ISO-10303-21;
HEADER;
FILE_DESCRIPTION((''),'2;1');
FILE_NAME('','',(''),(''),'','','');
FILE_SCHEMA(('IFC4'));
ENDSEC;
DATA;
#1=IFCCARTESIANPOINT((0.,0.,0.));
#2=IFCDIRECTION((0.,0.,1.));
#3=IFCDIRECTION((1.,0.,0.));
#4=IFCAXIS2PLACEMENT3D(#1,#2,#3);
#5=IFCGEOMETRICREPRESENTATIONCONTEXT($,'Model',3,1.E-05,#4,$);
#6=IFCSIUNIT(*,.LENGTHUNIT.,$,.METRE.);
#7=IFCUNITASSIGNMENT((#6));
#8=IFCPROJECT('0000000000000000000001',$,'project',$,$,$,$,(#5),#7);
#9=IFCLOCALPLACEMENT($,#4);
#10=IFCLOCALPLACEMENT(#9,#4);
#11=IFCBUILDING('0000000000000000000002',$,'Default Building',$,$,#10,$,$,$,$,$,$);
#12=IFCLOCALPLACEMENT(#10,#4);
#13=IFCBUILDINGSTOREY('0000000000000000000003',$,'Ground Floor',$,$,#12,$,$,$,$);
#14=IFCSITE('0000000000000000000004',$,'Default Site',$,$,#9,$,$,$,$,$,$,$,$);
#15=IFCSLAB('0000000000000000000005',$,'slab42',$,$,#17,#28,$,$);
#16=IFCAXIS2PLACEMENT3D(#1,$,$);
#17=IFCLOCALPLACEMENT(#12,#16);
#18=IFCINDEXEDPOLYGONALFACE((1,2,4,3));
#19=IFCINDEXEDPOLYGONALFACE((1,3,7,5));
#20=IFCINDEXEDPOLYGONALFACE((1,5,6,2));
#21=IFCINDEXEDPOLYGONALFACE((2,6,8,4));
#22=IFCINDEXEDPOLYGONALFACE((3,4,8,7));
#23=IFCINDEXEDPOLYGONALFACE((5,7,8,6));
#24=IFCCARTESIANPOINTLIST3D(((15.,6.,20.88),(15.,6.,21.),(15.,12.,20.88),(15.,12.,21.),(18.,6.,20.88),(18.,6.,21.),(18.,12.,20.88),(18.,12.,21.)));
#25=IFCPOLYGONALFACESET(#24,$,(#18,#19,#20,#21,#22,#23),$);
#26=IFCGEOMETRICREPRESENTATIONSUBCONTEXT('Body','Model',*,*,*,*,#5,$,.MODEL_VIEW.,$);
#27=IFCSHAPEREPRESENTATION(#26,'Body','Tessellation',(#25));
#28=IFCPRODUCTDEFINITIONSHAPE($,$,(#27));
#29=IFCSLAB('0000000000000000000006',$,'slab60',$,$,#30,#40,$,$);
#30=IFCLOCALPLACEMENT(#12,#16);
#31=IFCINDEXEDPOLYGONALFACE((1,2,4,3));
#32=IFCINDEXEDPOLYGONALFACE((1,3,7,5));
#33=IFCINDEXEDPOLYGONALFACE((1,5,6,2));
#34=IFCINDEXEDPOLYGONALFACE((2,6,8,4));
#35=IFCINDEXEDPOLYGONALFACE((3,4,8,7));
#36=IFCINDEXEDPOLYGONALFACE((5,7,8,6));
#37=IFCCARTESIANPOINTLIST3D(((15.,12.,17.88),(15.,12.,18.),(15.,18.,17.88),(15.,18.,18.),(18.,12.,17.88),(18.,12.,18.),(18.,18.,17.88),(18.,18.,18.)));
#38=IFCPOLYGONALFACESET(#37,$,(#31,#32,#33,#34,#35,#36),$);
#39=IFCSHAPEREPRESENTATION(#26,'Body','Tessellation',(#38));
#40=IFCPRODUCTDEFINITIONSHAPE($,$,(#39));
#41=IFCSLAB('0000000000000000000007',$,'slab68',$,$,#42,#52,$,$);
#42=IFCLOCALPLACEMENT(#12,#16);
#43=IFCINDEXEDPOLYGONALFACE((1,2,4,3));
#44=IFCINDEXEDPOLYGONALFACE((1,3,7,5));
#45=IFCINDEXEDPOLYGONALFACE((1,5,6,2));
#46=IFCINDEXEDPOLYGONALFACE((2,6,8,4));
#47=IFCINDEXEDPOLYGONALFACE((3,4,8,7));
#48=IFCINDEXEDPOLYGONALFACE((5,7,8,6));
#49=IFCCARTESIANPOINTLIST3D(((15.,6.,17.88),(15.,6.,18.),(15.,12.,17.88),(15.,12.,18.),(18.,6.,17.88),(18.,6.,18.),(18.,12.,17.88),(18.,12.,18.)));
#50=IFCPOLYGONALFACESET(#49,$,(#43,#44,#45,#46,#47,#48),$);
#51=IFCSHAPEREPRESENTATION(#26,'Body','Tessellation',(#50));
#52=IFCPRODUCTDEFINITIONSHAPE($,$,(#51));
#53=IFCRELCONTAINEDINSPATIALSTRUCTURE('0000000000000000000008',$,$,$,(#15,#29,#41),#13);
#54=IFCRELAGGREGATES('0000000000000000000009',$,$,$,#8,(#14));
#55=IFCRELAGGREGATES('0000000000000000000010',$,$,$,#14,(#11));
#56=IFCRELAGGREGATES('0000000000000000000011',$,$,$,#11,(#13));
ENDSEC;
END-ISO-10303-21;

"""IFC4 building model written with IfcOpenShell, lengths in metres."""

from ifc_helpers import new_model, si_unit, frame, origin_with_axes, place, context, subcontext, project, spatial, indexed_curve, outline, extrude, element, save


model = new_model("IFC4")

# Units and contexts
model_context = context("Model", 3, precision=1e-05, world=origin_with_axes())
body_context = subcontext(model_context, "Body", "Model", "MODEL_VIEW")
ifc_project = project(units=[si_unit("LENGTHUNIT", "METRE")], contexts=[model_context])

# Site, building, storey
site_placement = place(None, origin_with_axes())
site = spatial("IfcSite", under=ifc_project, at=site_placement, Name="Default Site")
building_placement = place(site_placement, origin_with_axes())
building = spatial("IfcBuilding", under=site, at=building_placement, Name="Default Building")
storey_placement = place(building_placement, origin_with_axes())
storey = spatial("IfcBuildingStorey", under=building, at=storey_placement, Name="Ground Floor")

# Slabs
for number, where, z_axis, x_axis, name in (
    (1, (15.0, 6.0, 20.88), (0.0, 0.0, 1.0), (1.0, 0.0, 0.0), "slab42"),
    (2, (15.0, 12.0, 17.88), (0.0, 0.0, 1.0), (1.0, 0.0, 0.0), "slab60"),
    (3, (15.0, 6.0, 17.88), (0.0, 0.0, 1.0), (1.0, 0.0, 0.0), "slab68"),
):
    element("IfcSlab", number, at=place(storey_placement, frame(where, z_axis=z_axis, x_axis=x_axis)), inside=storey, Name=name, context=body_context, shape_type="SweptSolid", body=[
        extrude(outline(indexed_curve([(0.0, 0.0), (0.0, 6.0), (3.0, 6.0), (3.0, 0.0), (0.0, 0.0)], self_intersect=False)), origin_with_axes(), (0.0, 0.0, 1.0), 0.12),
    ])

save(model, "model.ifc")
